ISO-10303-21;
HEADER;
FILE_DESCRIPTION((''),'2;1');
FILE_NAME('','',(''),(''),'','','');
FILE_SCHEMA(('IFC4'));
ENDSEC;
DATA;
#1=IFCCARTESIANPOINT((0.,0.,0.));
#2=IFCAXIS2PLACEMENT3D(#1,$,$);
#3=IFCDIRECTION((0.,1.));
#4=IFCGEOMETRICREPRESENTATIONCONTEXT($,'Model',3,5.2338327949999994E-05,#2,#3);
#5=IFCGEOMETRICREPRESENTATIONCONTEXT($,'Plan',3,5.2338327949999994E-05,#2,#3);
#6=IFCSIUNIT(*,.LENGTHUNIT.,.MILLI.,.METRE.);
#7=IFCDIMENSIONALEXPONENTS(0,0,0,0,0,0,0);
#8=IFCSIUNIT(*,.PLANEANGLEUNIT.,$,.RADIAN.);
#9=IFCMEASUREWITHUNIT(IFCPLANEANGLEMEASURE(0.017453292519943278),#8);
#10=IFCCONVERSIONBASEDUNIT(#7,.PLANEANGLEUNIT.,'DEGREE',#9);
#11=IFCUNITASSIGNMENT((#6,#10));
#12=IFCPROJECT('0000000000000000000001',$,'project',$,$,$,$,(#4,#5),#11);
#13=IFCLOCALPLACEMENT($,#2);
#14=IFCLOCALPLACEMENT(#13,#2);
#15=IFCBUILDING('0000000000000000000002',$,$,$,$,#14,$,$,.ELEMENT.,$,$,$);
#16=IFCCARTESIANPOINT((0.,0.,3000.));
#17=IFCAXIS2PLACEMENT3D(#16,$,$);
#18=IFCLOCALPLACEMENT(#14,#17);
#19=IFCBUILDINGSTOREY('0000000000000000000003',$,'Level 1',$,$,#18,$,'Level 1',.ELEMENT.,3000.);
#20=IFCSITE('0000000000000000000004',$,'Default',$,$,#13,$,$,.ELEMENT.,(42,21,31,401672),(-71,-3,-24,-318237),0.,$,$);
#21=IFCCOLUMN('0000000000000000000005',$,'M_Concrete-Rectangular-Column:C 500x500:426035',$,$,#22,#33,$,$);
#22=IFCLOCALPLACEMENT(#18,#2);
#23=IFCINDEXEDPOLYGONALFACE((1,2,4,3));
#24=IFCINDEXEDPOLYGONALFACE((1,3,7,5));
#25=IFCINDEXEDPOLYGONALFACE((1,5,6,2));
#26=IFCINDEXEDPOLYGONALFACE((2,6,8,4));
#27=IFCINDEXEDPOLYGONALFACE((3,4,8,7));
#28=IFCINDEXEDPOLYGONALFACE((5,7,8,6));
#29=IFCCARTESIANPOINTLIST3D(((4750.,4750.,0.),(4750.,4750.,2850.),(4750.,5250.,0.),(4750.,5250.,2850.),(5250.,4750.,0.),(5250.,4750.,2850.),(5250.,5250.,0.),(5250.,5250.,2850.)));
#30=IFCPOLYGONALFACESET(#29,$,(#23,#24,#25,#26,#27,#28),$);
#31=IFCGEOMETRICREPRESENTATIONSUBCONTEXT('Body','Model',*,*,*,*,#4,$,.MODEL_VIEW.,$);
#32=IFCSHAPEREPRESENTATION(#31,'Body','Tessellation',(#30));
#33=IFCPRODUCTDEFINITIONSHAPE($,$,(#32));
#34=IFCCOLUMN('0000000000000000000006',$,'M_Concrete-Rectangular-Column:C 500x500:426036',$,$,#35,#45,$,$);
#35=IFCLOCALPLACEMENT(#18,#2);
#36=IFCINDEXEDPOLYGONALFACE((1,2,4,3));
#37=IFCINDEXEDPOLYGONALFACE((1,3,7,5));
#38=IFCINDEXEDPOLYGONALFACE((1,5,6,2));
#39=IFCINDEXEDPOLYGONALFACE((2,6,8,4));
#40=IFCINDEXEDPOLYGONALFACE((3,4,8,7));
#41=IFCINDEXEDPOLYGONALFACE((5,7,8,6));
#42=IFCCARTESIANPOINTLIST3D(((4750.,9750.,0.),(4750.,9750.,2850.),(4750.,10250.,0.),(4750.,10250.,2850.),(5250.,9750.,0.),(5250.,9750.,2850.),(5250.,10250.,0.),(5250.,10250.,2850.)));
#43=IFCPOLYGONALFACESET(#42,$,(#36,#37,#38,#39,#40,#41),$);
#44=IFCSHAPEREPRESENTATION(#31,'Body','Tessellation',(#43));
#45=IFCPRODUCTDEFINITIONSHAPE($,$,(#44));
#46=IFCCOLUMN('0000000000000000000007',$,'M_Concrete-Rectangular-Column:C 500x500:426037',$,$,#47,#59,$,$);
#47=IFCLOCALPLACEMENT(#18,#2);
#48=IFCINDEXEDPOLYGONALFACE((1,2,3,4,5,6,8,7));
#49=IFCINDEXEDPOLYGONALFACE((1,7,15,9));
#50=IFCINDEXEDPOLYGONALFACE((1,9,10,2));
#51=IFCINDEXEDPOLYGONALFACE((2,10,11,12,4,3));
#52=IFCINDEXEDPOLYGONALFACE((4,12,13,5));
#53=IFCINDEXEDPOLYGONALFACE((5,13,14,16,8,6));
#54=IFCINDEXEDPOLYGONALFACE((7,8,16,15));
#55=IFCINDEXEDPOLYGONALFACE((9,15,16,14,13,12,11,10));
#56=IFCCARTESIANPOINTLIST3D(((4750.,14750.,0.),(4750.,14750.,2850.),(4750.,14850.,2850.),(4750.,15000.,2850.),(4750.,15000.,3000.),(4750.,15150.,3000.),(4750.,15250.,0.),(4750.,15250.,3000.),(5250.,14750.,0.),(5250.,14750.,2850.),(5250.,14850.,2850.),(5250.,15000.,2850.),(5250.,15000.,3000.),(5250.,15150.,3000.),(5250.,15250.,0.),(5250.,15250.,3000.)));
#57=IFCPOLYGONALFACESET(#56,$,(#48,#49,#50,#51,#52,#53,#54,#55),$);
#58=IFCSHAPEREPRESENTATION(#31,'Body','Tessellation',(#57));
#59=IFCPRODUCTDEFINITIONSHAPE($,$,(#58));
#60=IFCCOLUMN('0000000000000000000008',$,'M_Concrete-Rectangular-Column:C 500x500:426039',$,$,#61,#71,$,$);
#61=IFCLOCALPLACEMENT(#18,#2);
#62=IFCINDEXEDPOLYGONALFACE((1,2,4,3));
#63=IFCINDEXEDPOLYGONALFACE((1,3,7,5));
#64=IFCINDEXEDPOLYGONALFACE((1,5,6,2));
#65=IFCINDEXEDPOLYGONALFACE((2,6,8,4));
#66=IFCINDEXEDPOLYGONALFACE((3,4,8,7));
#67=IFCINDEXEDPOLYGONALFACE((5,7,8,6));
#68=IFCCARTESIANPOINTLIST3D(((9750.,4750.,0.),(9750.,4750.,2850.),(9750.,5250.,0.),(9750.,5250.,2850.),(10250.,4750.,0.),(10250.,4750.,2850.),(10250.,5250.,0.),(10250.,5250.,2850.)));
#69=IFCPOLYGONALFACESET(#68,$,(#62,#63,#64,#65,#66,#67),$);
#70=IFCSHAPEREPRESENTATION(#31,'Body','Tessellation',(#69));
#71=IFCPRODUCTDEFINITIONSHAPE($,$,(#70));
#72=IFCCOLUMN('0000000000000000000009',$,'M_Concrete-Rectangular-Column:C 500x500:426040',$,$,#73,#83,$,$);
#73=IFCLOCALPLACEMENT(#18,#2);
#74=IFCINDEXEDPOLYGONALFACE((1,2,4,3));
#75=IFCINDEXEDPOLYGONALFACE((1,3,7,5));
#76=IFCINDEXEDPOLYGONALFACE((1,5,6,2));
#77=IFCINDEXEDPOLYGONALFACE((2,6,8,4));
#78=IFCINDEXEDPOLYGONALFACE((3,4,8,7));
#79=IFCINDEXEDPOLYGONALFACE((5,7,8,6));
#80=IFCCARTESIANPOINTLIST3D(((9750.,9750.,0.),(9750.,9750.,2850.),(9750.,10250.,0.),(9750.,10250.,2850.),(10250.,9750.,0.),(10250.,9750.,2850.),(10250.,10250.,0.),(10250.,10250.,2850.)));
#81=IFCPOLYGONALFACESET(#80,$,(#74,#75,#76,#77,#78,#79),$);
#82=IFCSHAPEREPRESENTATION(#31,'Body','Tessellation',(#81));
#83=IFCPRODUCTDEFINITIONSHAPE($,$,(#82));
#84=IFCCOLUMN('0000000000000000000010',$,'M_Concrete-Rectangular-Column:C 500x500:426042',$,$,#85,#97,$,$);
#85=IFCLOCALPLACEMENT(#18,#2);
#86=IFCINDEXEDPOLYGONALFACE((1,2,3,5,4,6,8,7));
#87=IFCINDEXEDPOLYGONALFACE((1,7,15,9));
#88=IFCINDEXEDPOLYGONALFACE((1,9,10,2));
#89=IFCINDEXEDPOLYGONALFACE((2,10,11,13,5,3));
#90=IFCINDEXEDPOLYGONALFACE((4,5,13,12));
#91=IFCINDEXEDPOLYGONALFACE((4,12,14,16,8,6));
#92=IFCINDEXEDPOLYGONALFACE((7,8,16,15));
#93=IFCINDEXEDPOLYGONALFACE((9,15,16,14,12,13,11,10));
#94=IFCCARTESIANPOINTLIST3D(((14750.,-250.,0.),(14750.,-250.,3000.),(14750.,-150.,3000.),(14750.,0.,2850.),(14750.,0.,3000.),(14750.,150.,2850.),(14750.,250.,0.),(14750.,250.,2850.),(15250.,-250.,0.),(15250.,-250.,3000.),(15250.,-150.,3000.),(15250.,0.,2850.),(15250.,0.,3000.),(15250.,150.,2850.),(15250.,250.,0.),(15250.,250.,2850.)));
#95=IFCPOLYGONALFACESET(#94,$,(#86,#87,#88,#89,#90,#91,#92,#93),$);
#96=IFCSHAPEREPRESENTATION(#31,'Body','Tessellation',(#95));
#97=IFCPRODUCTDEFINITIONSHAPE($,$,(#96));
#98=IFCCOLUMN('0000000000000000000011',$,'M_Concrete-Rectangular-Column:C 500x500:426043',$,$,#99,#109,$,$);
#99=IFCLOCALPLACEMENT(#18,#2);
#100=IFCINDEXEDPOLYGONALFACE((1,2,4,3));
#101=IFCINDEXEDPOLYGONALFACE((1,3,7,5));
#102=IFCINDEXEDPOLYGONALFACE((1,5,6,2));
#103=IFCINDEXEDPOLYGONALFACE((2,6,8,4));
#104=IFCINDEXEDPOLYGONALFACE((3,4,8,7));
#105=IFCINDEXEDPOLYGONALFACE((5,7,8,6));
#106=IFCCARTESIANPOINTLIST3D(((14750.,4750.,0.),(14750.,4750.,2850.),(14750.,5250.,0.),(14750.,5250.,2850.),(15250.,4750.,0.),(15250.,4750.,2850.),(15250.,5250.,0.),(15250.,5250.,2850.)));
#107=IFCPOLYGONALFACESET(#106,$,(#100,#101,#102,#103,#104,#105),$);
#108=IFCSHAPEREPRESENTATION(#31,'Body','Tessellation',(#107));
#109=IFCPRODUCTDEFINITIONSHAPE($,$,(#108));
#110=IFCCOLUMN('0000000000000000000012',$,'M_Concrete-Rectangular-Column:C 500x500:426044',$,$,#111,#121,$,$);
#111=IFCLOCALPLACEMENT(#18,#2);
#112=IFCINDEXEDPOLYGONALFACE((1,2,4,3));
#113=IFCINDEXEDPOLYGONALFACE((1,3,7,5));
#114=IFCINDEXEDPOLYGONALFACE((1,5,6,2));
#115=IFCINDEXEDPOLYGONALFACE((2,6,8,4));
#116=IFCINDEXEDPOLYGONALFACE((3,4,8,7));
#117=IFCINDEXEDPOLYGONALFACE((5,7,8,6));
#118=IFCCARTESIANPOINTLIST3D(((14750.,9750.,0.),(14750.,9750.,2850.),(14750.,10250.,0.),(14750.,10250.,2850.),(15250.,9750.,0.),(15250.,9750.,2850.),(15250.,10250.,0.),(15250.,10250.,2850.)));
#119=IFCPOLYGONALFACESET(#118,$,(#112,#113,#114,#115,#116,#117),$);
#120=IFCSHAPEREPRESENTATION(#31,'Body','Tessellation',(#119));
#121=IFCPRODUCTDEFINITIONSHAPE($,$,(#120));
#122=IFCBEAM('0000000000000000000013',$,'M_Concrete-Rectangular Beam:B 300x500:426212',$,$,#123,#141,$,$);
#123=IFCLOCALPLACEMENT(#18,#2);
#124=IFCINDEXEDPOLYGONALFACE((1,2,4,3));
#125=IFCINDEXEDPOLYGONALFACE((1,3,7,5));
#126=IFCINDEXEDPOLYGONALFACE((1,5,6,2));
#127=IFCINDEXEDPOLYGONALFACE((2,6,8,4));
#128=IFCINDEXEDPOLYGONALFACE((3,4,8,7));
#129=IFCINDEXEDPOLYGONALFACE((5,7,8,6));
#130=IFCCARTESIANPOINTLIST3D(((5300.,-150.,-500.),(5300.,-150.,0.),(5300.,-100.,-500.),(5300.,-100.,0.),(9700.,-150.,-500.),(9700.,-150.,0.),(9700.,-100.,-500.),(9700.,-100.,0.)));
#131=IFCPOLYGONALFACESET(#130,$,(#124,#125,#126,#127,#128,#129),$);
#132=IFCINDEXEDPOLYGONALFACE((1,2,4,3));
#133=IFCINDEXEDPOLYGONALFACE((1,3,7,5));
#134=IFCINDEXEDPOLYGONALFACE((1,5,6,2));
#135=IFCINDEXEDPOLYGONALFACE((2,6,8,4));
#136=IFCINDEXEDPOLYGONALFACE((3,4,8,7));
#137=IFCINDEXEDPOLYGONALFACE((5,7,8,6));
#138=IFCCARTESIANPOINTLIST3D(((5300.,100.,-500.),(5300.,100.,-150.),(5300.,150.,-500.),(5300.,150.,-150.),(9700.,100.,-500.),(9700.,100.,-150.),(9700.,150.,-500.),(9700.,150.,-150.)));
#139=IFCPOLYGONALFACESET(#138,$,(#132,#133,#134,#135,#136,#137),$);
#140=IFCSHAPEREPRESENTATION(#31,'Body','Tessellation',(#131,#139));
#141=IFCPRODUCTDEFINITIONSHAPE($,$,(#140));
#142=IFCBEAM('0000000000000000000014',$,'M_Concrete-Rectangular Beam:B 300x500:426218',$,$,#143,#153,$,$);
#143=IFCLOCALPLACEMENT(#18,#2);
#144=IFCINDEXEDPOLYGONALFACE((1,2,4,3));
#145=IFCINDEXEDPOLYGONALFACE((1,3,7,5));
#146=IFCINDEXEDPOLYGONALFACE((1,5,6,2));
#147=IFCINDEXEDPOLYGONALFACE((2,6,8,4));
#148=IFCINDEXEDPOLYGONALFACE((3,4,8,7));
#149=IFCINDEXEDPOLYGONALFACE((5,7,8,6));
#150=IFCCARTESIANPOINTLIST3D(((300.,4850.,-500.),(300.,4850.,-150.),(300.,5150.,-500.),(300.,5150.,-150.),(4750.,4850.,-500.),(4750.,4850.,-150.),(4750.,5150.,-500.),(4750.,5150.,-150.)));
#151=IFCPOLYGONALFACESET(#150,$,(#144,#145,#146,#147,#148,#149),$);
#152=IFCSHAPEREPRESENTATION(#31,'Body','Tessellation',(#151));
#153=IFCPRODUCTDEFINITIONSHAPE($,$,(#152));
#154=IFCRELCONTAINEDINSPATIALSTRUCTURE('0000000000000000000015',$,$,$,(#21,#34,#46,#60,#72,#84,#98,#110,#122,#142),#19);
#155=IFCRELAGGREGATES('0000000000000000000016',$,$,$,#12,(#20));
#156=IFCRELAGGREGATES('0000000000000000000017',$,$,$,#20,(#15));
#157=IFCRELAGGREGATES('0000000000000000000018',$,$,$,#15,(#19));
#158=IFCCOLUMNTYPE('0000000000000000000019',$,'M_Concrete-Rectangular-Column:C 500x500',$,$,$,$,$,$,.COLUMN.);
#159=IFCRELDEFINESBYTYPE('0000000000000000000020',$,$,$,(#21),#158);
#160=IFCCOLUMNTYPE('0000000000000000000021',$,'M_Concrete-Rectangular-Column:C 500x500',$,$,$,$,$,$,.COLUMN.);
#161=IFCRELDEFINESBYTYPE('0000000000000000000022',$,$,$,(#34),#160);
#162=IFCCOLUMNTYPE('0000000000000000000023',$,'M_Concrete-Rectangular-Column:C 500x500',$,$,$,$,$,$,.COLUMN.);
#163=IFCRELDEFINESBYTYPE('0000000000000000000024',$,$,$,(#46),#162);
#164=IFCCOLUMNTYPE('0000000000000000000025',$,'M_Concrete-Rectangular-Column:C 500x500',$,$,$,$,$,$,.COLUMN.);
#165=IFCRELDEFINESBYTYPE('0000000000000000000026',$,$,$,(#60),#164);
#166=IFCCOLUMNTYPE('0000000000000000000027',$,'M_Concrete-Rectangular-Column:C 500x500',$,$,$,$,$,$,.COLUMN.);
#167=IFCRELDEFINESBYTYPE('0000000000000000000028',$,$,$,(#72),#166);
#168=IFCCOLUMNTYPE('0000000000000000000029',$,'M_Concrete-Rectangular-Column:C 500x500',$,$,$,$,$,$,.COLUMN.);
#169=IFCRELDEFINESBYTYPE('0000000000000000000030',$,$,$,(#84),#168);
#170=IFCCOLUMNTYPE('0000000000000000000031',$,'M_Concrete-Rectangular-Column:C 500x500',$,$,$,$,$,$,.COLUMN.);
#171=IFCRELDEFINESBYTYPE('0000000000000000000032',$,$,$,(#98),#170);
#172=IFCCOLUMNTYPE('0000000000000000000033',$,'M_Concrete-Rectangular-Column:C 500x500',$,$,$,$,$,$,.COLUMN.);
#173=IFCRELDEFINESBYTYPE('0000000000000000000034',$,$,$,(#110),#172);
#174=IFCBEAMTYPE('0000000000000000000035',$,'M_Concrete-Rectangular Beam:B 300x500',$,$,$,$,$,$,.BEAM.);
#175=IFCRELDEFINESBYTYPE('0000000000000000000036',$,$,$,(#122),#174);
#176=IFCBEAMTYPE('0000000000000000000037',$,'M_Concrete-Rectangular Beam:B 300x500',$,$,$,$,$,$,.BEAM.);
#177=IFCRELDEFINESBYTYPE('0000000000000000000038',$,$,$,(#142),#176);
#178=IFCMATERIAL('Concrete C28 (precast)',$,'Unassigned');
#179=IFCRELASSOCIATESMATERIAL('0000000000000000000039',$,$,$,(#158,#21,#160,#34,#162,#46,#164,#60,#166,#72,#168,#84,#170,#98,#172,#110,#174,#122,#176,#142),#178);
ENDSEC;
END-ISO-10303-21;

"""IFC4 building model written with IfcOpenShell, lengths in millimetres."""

from ifc_helpers import new_model, entity, si_unit, converted_unit, direction, frame, origin, place, context, subcontext, project, spatial, indexed_curve, outline, extrude, source, transform, mapped, material, type_object, type_shapes, element, save


model = new_model("IFC4")

# Units and contexts
model_context = context("Model", 3, precision=5.2338327949999994e-05, world=origin(), true_north=direction((0.0, 1.0)))
plan_context = context("Plan", 3, precision=5.2338327949999994e-05, world=origin(), true_north=direction((0.0, 1.0)))
body_context = subcontext(model_context, "Body", "Model", "MODEL_VIEW")
ifc_project = project(units=[si_unit("LENGTHUNIT", "METRE", prefix="MILLI"), converted_unit("PLANEANGLEUNIT", "DEGREE", entity("IfcPlaneAngleMeasure", 0.017453292519943278), si_unit("PLANEANGLEUNIT", "RADIAN"), dimensions=[0, 0, 0, 0, 0, 0, 0])], contexts=[model_context, plan_context])

# Site, building, storey
site_placement = place(None, origin())
site = spatial("IfcSite", under=ifc_project, at=site_placement, Name="Default", CompositionType="ELEMENT", RefLatitude=(42, 21, 31, 401672), RefLongitude=(-71, -3, -24, -318237), RefElevation=0.0)
building_placement = place(site_placement, origin())
building = spatial("IfcBuilding", under=site, at=building_placement, CompositionType="ELEMENT")
storey_placement = place(building_placement, frame((0.0, 0.0, 3000.0)))
storey = spatial("IfcBuildingStorey", under=building, at=storey_placement, Name="Level 1", LongName="Level 1", CompositionType="ELEMENT", Elevation=3000.0)

# Columns
ifc_material = material(Name="Concrete C28 (precast)", Category="Unassigned")
column_type_1 = type_object("IfcColumnType", Name="M_Concrete-Rectangular-Column:C 500x500", PredefinedType="COLUMN", material=ifc_material)
shared_shape_1 = source(origin(), body_context, "Body", "SweptSolid", [
    extrude(outline(indexed_curve([(-250.0, -250.0), (250.0, -250.0), (250.0, 250.0), (-250.0, 250.0), (-250.0, -250.0)], self_intersect=False)), frame((5000.0, 5000.0, 3000.0), z_axis=(0.0, 0.0, 1.0), x_axis=(-1.0, 0.0, 0.0)), (0.0, 0.0, 1.0), 2850.0),
])
type_shapes(column_type_1, [shared_shape_1])
column_1_placement = place(storey_placement, frame((0.0, 0.0, -3000.0)))
element("IfcColumn", 1, at=column_1_placement, inside=storey, type_object=column_type_1, material=ifc_material, Name="M_Concrete-Rectangular-Column:C 500x500:426035", context=body_context, shape_type="MappedRepresentation", body=[
    mapped(shared_shape_1, transform((0.0, 0.0, 0.0), scale=1.0)),
])
column_type_2 = type_object("IfcColumnType", Name="M_Concrete-Rectangular-Column:C 500x500", PredefinedType="COLUMN", material=ifc_material)
shared_shape_2 = source(origin(), body_context, "Body", "SweptSolid", [
    extrude(outline(indexed_curve([(-250.0, -250.0), (250.0, -250.0), (250.0, 250.0), (-250.0, 250.0), (-250.0, -250.0)], self_intersect=False)), frame((5000.0, 10000.0, 3000.0), z_axis=(0.0, 0.0, 1.0), x_axis=(-1.0, 0.0, 0.0)), (0.0, 0.0, 1.0), 2850.0),
])
type_shapes(column_type_2, [shared_shape_2])
column_2_placement = place(storey_placement, frame((0.0, 0.0, -3000.0)))
element("IfcColumn", 2, at=column_2_placement, inside=storey, type_object=column_type_2, material=ifc_material, Name="M_Concrete-Rectangular-Column:C 500x500:426036", context=body_context, shape_type="MappedRepresentation", body=[
    mapped(shared_shape_2, transform((0.0, 0.0, 0.0), scale=1.0)),
])
column_type_3 = type_object("IfcColumnType", Name="M_Concrete-Rectangular-Column:C 500x500", PredefinedType="COLUMN", material=ifc_material)
shared_shape_3 = source(origin(), body_context, "Body", "SweptSolid", [
    extrude(outline(indexed_curve([(-2193.8, -250.0), (806.2, -250.0), (806.2, -150.0), (806.2, 0.0), (656.3, 0.0), (656.3, 150.0), (656.3, 250.0), (-2193.8, 250.0), (-2193.8, -250.0)], self_intersect=False)), frame((4750.0, 15000.0, 5193.8), z_axis=(1.0, 0.0, 0.0), x_axis=(0.0, 0.0, 1.0)), (0.0, 0.0, 1.0), 500.0),
])
type_shapes(column_type_3, [shared_shape_3])
column_3_placement = place(storey_placement, frame((0.0, 0.0, -3000.0)))
element("IfcColumn", 3, at=column_3_placement, inside=storey, type_object=column_type_3, material=ifc_material, Name="M_Concrete-Rectangular-Column:C 500x500:426037", context=body_context, shape_type="MappedRepresentation", body=[
    mapped(shared_shape_3, transform((0.0, 0.0, 0.0), scale=1.0)),
])
column_type_4 = type_object("IfcColumnType", Name="M_Concrete-Rectangular-Column:C 500x500", PredefinedType="COLUMN", material=ifc_material)
shared_shape_4 = source(origin(), body_context, "Body", "SweptSolid", [
    extrude(outline(indexed_curve([(-250.0, -250.0), (250.0, -250.0), (250.0, 250.0), (-250.0, 250.0), (-250.0, -250.0)], self_intersect=False)), frame((10000.0, 5000.0, 3000.0), z_axis=(0.0, 0.0, 1.0), x_axis=(-1.0, 0.0, 0.0)), (0.0, 0.0, 1.0), 2850.0),
])
type_shapes(column_type_4, [shared_shape_4])
column_4_placement = place(storey_placement, frame((0.0, 0.0, -3000.0)))
element("IfcColumn", 4, at=column_4_placement, inside=storey, type_object=column_type_4, material=ifc_material, Name="M_Concrete-Rectangular-Column:C 500x500:426039", context=body_context, shape_type="MappedRepresentation", body=[
    mapped(shared_shape_4, transform((0.0, 0.0, 0.0), scale=1.0)),
])
column_type_5 = type_object("IfcColumnType", Name="M_Concrete-Rectangular-Column:C 500x500", PredefinedType="COLUMN", material=ifc_material)
shared_shape_5 = source(origin(), body_context, "Body", "SweptSolid", [
    extrude(outline(indexed_curve([(-250.0, -250.0), (250.0, -250.0), (250.0, 250.0), (-250.0, 250.0), (-250.0, -250.0)], self_intersect=False)), frame((10000.0, 10000.0, 3000.0), z_axis=(0.0, 0.0, 1.0), x_axis=(-1.0, 0.0, 0.0)), (0.0, 0.0, 1.0), 2850.0),
])
type_shapes(column_type_5, [shared_shape_5])
column_5_placement = place(storey_placement, frame((0.0, 0.0, -3000.0)))
element("IfcColumn", 5, at=column_5_placement, inside=storey, type_object=column_type_5, material=ifc_material, Name="M_Concrete-Rectangular-Column:C 500x500:426040", context=body_context, shape_type="MappedRepresentation", body=[
    mapped(shared_shape_5, transform((0.0, 0.0, 0.0), scale=1.0)),
])
column_type_6 = type_object("IfcColumnType", Name="M_Concrete-Rectangular-Column:C 500x500", PredefinedType="COLUMN", material=ifc_material)
shared_shape_6 = source(origin(), body_context, "Body", "SweptSolid", [
    extrude(outline(indexed_curve([(-2193.8, -250.0), (656.3, -250.0), (656.3, -150.0), (656.3, 0.0), (806.2, 0.0), (806.2, 150.0), (806.2, 250.0), (-2193.8, 250.0), (-2193.8, -250.0)], self_intersect=False)), frame((14750.0, 0.0, 5193.8), z_axis=(1.0, 0.0, 0.0), x_axis=(0.0, 0.0, 1.0)), (0.0, 0.0, 1.0), 500.0),
])
type_shapes(column_type_6, [shared_shape_6])
column_6_placement = place(storey_placement, frame((0.0, 0.0, -3000.0)))
element("IfcColumn", 6, at=column_6_placement, inside=storey, type_object=column_type_6, material=ifc_material, Name="M_Concrete-Rectangular-Column:C 500x500:426042", context=body_context, shape_type="MappedRepresentation", body=[
    mapped(shared_shape_6, transform((0.0, 0.0, 0.0), scale=1.0)),
])
column_type_7 = type_object("IfcColumnType", Name="M_Concrete-Rectangular-Column:C 500x500", PredefinedType="COLUMN", material=ifc_material)
shared_shape_7 = source(origin(), body_context, "Body", "SweptSolid", [
    extrude(outline(indexed_curve([(-250.0, -250.0), (250.0, -250.0), (250.0, 250.0), (-250.0, 250.0), (-250.0, -250.0)], self_intersect=False)), frame((15000.0, 5000.0, 3000.0), z_axis=(0.0, 0.0, 1.0), x_axis=(-1.0, 0.0, 0.0)), (0.0, 0.0, 1.0), 2850.0),
])
type_shapes(column_type_7, [shared_shape_7])
column_7_placement = place(storey_placement, frame((0.0, 0.0, -3000.0)))
element("IfcColumn", 7, at=column_7_placement, inside=storey, type_object=column_type_7, material=ifc_material, Name="M_Concrete-Rectangular-Column:C 500x500:426043", context=body_context, shape_type="MappedRepresentation", body=[
    mapped(shared_shape_7, transform((0.0, 0.0, 0.0), scale=1.0)),
])
column_type_8 = type_object("IfcColumnType", Name="M_Concrete-Rectangular-Column:C 500x500", PredefinedType="COLUMN", material=ifc_material)
shared_shape_8 = source(origin(), body_context, "Body", "SweptSolid", [
    extrude(outline(indexed_curve([(-250.0, -250.0), (250.0, -250.0), (250.0, 250.0), (-250.0, 250.0), (-250.0, -250.0)], self_intersect=False)), frame((15000.0, 10000.0, 3000.0), z_axis=(0.0, 0.0, 1.0), x_axis=(-1.0, 0.0, 0.0)), (0.0, 0.0, 1.0), 2850.0),
])
type_shapes(column_type_8, [shared_shape_8])
column_8_placement = place(storey_placement, frame((0.0, 0.0, -3000.0)))
element("IfcColumn", 8, at=column_8_placement, inside=storey, type_object=column_type_8, material=ifc_material, Name="M_Concrete-Rectangular-Column:C 500x500:426044", context=body_context, shape_type="MappedRepresentation", body=[
    mapped(shared_shape_8, transform((0.0, 0.0, 0.0), scale=1.0)),
])

# Beams
beam_type_1 = type_object("IfcBeamType", Name="M_Concrete-Rectangular Beam:B 300x500", PredefinedType="BEAM", material=ifc_material)
shared_shape_9 = source(origin(), body_context, "Body", "SweptSolid", [
    extrude(outline(indexed_curve([(-250.0, -25.0), (250.0, -25.0), (250.0, 25.0), (-250.0, 25.0), (-250.0, -25.0)], self_intersect=False)), frame((5300.0, -125.0, 2750.0), z_axis=(1.0, 0.0, 0.0), x_axis=(0.0, 0.0, -1.0)), (0.0, 0.0, 1.0), 4400.0),
    extrude(outline(indexed_curve([(-175.0, -25.0), (175.0, -25.0), (175.0, 25.0), (-175.0, 25.0), (-175.0, -25.0)], self_intersect=False)), frame((5300.0, 125.0, 2675.0), z_axis=(1.0, 0.0, 0.0), x_axis=(0.0, 0.0, -1.0)), (0.0, 0.0, 1.0), 4400.0),
])
type_shapes(beam_type_1, [shared_shape_9])
beam_1_placement = place(storey_placement, frame((0.0, 0.0, -3000.0)))
element("IfcBeam", 9, at=beam_1_placement, inside=storey, type_object=beam_type_1, material=ifc_material, Name="M_Concrete-Rectangular Beam:B 300x500:426212", context=body_context, shape_type="MappedRepresentation", body=[
    mapped(shared_shape_9, transform((0.0, 0.0, 0.0), scale=1.0)),
])
beam_type_2 = type_object("IfcBeamType", Name="M_Concrete-Rectangular Beam:B 300x500", PredefinedType="BEAM", material=ifc_material)
shared_shape_10 = source(origin(), body_context, "Body", "SweptSolid", [
    extrude(outline(indexed_curve([(-175.0, -150.0), (175.0, -150.0), (175.0, 150.0), (-175.0, 150.0), (-175.0, -150.0)], self_intersect=False)), frame((300.0, 5000.0, 2675.0), z_axis=(1.0, 0.0, 0.0), x_axis=(0.0, 0.0, -1.0)), (0.0, 0.0, 1.0), 4450.0),
])
type_shapes(beam_type_2, [shared_shape_10])
beam_2_placement = place(storey_placement, frame((0.0, 0.0, -3000.0)))
element("IfcBeam", 10, at=beam_2_placement, inside=storey, type_object=beam_type_2, material=ifc_material, Name="M_Concrete-Rectangular Beam:B 300x500:426218", context=body_context, shape_type="MappedRepresentation", body=[
    mapped(shared_shape_10, transform((0.0, 0.0, 0.0), scale=1.0)),
])

save(model, "model.ifc")
